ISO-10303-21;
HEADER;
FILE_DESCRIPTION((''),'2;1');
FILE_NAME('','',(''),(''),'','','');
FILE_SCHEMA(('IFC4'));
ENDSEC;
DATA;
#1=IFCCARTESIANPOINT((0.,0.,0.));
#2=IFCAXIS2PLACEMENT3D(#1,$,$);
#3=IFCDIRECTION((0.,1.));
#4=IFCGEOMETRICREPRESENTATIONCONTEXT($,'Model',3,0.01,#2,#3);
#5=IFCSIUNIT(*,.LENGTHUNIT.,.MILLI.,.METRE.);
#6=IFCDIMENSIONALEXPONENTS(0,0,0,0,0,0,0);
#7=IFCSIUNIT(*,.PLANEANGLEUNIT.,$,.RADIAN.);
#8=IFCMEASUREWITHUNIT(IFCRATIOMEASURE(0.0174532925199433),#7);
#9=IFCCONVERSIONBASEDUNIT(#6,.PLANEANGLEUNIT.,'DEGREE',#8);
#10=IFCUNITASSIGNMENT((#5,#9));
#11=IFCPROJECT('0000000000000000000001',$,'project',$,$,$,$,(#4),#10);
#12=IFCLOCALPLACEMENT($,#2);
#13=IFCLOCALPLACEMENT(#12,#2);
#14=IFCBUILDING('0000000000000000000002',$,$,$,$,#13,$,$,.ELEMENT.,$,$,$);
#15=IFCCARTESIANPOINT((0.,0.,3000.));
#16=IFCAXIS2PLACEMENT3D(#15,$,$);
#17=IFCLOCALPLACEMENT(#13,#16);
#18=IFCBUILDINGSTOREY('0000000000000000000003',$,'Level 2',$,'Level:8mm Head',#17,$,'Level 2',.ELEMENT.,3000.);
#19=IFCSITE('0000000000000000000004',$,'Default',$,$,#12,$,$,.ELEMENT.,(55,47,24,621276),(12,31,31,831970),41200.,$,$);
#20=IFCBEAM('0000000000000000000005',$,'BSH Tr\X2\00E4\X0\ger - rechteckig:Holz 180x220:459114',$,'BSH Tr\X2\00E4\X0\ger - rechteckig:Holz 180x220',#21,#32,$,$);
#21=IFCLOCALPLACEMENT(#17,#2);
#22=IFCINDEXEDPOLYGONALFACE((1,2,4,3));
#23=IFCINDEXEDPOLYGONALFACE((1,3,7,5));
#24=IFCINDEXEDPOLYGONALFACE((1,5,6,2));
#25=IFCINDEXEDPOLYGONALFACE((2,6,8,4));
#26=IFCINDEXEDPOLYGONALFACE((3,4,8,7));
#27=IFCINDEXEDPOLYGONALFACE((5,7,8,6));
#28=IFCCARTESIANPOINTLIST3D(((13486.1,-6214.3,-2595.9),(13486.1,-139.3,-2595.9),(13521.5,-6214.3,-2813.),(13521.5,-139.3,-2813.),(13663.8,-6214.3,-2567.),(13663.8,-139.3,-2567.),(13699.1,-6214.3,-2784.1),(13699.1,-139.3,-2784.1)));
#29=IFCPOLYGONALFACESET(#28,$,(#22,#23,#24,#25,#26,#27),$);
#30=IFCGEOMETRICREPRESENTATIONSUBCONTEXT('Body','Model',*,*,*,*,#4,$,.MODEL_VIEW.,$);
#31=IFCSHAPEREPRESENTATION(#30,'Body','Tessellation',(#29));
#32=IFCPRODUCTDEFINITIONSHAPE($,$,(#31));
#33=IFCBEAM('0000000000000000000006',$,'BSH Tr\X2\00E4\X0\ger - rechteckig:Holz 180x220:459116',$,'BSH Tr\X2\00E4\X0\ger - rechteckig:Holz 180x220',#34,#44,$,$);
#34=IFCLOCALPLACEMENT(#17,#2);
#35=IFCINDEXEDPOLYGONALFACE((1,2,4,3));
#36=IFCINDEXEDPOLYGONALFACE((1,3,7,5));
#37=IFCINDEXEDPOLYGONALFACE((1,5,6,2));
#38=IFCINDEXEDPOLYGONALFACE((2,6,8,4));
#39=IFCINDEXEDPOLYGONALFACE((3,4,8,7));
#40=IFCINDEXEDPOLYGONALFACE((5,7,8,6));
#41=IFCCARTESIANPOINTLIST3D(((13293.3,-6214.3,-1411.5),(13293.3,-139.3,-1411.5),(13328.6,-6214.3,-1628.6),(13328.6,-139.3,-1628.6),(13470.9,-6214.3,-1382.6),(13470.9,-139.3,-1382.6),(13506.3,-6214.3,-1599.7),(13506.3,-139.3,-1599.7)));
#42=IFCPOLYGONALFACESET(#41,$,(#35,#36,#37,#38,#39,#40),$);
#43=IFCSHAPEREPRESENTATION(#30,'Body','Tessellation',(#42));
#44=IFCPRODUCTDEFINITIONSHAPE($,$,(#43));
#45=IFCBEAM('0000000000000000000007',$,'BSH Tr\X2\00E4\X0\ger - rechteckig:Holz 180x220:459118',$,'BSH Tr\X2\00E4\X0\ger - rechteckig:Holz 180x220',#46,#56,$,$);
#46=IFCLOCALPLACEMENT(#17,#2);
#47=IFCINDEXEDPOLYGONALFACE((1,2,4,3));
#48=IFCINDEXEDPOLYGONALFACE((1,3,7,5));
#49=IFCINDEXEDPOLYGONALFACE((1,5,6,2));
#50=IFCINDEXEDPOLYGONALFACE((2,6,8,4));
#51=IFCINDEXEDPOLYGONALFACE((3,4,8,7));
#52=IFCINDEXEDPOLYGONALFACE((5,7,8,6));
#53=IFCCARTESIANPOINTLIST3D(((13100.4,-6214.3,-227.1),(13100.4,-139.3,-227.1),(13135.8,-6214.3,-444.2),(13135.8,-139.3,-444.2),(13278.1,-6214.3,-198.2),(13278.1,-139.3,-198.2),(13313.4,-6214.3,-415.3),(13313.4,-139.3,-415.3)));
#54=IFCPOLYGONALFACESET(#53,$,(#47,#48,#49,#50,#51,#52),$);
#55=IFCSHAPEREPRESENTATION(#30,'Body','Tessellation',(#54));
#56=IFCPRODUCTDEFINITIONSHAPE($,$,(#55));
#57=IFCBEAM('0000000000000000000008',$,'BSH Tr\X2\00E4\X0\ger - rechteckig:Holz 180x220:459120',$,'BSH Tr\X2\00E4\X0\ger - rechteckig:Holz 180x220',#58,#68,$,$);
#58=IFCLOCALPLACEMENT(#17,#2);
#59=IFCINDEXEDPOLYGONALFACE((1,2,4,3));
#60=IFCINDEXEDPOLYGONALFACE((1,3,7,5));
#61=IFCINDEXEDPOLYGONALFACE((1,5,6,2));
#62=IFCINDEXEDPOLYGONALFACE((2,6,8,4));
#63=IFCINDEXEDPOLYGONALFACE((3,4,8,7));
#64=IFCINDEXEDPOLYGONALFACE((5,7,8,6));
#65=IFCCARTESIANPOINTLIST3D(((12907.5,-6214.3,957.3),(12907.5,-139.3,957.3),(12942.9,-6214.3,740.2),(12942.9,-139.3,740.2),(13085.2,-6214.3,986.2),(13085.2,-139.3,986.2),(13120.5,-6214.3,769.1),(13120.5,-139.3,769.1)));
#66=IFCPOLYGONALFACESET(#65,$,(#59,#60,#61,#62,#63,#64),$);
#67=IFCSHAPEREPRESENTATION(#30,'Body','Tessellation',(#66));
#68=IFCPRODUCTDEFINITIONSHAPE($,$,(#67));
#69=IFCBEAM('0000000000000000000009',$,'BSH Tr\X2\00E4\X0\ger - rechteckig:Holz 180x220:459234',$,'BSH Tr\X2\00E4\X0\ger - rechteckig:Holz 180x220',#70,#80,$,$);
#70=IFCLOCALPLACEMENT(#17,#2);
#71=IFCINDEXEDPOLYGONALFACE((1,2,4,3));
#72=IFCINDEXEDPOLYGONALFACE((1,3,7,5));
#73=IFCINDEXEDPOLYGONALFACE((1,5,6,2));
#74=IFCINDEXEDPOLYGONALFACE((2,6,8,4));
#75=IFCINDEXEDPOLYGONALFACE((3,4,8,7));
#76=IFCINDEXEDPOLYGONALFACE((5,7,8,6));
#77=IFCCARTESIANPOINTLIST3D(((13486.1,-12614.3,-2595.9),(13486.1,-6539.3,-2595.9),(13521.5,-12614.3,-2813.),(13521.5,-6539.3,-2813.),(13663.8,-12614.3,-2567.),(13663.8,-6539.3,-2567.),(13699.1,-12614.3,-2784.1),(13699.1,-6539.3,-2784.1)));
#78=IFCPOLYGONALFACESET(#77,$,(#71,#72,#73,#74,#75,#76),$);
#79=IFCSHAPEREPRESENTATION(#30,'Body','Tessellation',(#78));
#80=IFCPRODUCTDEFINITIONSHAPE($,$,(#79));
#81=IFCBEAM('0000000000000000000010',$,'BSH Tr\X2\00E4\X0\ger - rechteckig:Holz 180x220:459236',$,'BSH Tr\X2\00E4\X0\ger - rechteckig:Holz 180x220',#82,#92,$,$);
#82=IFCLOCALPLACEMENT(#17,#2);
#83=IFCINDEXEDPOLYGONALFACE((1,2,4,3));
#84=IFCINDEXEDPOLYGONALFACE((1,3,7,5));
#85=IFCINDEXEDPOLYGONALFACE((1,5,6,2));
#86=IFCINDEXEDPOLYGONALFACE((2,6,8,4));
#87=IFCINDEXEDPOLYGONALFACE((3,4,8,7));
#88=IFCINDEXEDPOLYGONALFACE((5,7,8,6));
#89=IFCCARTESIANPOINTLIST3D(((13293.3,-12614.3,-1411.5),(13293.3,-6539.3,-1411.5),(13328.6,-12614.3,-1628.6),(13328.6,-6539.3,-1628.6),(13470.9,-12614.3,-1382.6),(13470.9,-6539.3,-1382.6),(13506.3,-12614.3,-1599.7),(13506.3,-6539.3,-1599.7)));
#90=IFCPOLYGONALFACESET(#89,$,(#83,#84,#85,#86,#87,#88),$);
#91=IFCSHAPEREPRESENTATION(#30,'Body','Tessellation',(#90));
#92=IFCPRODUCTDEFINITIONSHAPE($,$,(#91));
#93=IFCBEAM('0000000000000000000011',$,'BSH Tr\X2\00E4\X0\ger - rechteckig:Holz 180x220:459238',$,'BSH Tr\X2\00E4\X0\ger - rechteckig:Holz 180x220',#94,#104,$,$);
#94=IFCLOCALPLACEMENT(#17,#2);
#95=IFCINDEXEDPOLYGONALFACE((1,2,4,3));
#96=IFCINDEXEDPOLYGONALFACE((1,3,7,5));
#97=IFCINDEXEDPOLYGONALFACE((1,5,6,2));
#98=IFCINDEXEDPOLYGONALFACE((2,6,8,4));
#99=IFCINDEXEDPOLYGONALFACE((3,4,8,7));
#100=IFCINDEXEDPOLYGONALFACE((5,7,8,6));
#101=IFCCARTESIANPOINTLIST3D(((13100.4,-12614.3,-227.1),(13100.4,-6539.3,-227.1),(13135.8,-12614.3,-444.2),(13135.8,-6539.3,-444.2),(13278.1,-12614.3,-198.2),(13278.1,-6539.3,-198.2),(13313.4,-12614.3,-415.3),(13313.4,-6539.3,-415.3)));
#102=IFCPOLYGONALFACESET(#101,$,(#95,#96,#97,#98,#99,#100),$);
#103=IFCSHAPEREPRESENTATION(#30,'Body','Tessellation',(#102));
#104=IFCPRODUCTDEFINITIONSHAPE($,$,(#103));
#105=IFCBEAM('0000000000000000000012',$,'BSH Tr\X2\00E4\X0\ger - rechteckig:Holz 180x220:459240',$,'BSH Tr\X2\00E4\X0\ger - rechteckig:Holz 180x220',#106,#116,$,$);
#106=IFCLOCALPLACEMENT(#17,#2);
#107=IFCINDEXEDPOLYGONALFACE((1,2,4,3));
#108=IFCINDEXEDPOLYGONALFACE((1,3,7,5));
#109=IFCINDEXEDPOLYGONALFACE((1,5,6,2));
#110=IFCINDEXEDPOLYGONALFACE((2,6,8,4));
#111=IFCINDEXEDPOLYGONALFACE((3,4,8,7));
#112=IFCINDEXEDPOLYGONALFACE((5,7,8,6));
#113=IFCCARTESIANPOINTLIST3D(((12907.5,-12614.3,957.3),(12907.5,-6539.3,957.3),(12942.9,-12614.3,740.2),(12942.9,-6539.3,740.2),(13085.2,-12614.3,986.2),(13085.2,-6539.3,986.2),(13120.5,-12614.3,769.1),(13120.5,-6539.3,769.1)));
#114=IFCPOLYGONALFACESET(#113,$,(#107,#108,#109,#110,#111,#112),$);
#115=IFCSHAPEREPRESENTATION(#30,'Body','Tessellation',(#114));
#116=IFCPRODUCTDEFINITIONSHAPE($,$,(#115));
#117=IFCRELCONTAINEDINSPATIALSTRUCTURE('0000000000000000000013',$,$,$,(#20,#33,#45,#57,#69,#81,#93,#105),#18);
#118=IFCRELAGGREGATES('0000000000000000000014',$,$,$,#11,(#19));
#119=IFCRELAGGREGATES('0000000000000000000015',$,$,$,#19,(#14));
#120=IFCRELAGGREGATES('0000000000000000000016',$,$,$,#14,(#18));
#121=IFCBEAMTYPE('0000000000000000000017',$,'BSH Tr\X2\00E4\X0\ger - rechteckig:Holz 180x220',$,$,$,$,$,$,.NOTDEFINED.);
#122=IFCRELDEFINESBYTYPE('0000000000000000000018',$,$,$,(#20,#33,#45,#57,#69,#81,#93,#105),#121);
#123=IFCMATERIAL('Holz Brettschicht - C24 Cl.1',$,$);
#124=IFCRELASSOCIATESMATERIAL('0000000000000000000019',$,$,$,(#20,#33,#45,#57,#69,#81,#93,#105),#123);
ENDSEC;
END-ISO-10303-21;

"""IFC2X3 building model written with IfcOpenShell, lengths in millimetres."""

from ifc_helpers import new_model, entity, si_unit, converted_unit, direction, frame, frame_2d, origin, place, context, subcontext, project, spatial, rectangle, extrude, material, type_object, element, save


model = new_model("IFC2X3")

# Units and contexts
model_context = context("Model", 3, precision=0.01, world=origin(), true_north=direction((0.0, 1.0)))
body_context = subcontext(model_context, "Body", "Model", "MODEL_VIEW")
ifc_project = project(units=[si_unit("LENGTHUNIT", "METRE", prefix="MILLI"), converted_unit("PLANEANGLEUNIT", "DEGREE", entity("IfcRatioMeasure", 0.0174532925199433), si_unit("PLANEANGLEUNIT", "RADIAN"), dimensions=[0, 0, 0, 0, 0, 0, 0])], contexts=[model_context])

# Site, building, storey
site_placement = place(None, origin())
site = spatial("IfcSite", under=ifc_project, at=site_placement, Name="Default", CompositionType="ELEMENT", RefLatitude=(55, 47, 24, 621276), RefLongitude=(12, 31, 31, 831970), RefElevation=41200.0)
building_placement = place(site_placement, origin())
building = spatial("IfcBuilding", under=site, at=building_placement, CompositionType="ELEMENT")
storey_placement = place(building_placement, frame((0.0, 0.0, 3000.0)))
storey = spatial("IfcBuildingStorey", under=building, at=storey_placement, Name="Level 2", ObjectType="Level:8mm Head", LongName="Level 2", CompositionType="ELEMENT", Elevation=3000.0)

# Beams
ifc_material = material(Name="Holz Brettschicht - C24 Cl.1")
beam_type_1 = type_object("IfcBeamType", Name="BSH Träger - rechteckig:Holz 180x220", PredefinedType="NOTDEFINED")
beam_1_placement = place(storey_placement, frame((13681.5, -5476.8, -2675.5), z_axis=(0.0, 0.0, 1.0), x_axis=(0.0, 1.0, 0.0)))
element("IfcBeam", 1, at=beam_1_placement, inside=storey, type_object=beam_type_1, material=ifc_material, Name="BSH Träger - rechteckig:Holz 180x220:459114", ObjectType="BSH Träger - rechteckig:Holz 180x220", context=body_context, shape_type="SweptSolid", body=[
    extrude(rectangle(XDim=220.0, YDim=180.0, at=frame_2d((0.0, 0.0), x_axis=(1.0, 0.0))), frame((-737.5, 88.8, -14.5), z_axis=(1.0, 0.0, 0.0), x_axis=(0.0, 0.160724, 0.986999)), (0.0, 0.0, 1.0), 6075.0),
])
beam_2_placement = place(storey_placement, frame((13488.6, -5476.8, -1491.1), z_axis=(0.0, 0.0, 1.0), x_axis=(0.0, 1.0, 0.0)))
element("IfcBeam", 2, at=beam_2_placement, inside=storey, type_object=beam_type_1, material=ifc_material, Name="BSH Träger - rechteckig:Holz 180x220:459116", ObjectType="BSH Träger - rechteckig:Holz 180x220", context=body_context, shape_type="SweptSolid", body=[
    extrude(rectangle(XDim=220.0, YDim=180.0, at=frame_2d((0.0, 0.0), x_axis=(1.0, 0.0))), frame((-737.5, 88.8, -14.5), z_axis=(1.0, 0.0, 0.0), x_axis=(0.0, 0.160724, 0.986999)), (0.0, 0.0, 1.0), 6075.0),
])
beam_3_placement = place(storey_placement, frame((13295.7, -5476.8, -306.7), z_axis=(0.0, 0.0, 1.0), x_axis=(0.0, 1.0, 0.0)))
element("IfcBeam", 3, at=beam_3_placement, inside=storey, type_object=beam_type_1, material=ifc_material, Name="BSH Träger - rechteckig:Holz 180x220:459118", ObjectType="BSH Träger - rechteckig:Holz 180x220", context=body_context, shape_type="SweptSolid", body=[
    extrude(rectangle(XDim=220.0, YDim=180.0, at=frame_2d((0.0, 0.0), x_axis=(1.0, 0.0))), frame((-737.5, 88.8, -14.5), z_axis=(1.0, 0.0, 0.0), x_axis=(0.0, 0.160724, 0.986999)), (0.0, 0.0, 1.0), 6075.0),
])
beam_4_placement = place(storey_placement, frame((13102.9, -5476.8, 877.7), z_axis=(0.0, 0.0, 1.0), x_axis=(0.0, 1.0, 0.0)))
element("IfcBeam", 4, at=beam_4_placement, inside=storey, type_object=beam_type_1, material=ifc_material, Name="BSH Träger - rechteckig:Holz 180x220:459120", ObjectType="BSH Träger - rechteckig:Holz 180x220", context=body_context, shape_type="SweptSolid", body=[
    extrude(rectangle(XDim=220.0, YDim=180.0, at=frame_2d((0.0, 0.0), x_axis=(1.0, 0.0))), frame((-737.5, 88.8, -14.5), z_axis=(1.0, 0.0, 0.0), x_axis=(0.0, 0.160724, 0.986999)), (0.0, 0.0, 1.0), 6075.0),
])
beam_5_placement = place(storey_placement, frame((13681.5, -11876.8, -2675.5), z_axis=(0.0, 0.0, 1.0), x_axis=(0.0, 1.0, 0.0)))
element("IfcBeam", 5, at=beam_5_placement, inside=storey, type_object=beam_type_1, material=ifc_material, Name="BSH Träger - rechteckig:Holz 180x220:459234", ObjectType="BSH Träger - rechteckig:Holz 180x220", context=body_context, shape_type="SweptSolid", body=[
    extrude(rectangle(XDim=220.0, YDim=180.0, at=frame_2d((0.0, 0.0), x_axis=(1.0, 0.0))), frame((-737.5, 88.8, -14.5), z_axis=(1.0, 0.0, 0.0), x_axis=(0.0, 0.160724, 0.986999)), (0.0, 0.0, 1.0), 6075.0),
])
beam_6_placement = place(storey_placement, frame((13488.6, -11876.8, -1491.1), z_axis=(0.0, 0.0, 1.0), x_axis=(0.0, 1.0, 0.0)))
element("IfcBeam", 6, at=beam_6_placement, inside=storey, type_object=beam_type_1, material=ifc_material, Name="BSH Träger - rechteckig:Holz 180x220:459236", ObjectType="BSH Träger - rechteckig:Holz 180x220", context=body_context, shape_type="SweptSolid", body=[
    extrude(rectangle(XDim=220.0, YDim=180.0, at=frame_2d((0.0, 0.0), x_axis=(1.0, 0.0))), frame((-737.5, 88.8, -14.5), z_axis=(1.0, 0.0, 0.0), x_axis=(0.0, 0.160724, 0.986999)), (0.0, 0.0, 1.0), 6075.0),
])
beam_7_placement = place(storey_placement, frame((13295.7, -11876.8, -306.7), z_axis=(0.0, 0.0, 1.0), x_axis=(0.0, 1.0, 0.0)))
element("IfcBeam", 7, at=beam_7_placement, inside=storey, type_object=beam_type_1, material=ifc_material, Name="BSH Träger - rechteckig:Holz 180x220:459238", ObjectType="BSH Träger - rechteckig:Holz 180x220", context=body_context, shape_type="SweptSolid", body=[
    extrude(rectangle(XDim=220.0, YDim=180.0, at=frame_2d((0.0, 0.0), x_axis=(1.0, 0.0))), frame((-737.5, 88.8, -14.5), z_axis=(1.0, 0.0, 0.0), x_axis=(0.0, 0.160724, 0.986999)), (0.0, 0.0, 1.0), 6075.0),
])
beam_8_placement = place(storey_placement, frame((13102.9, -11876.8, 877.7), z_axis=(0.0, 0.0, 1.0), x_axis=(0.0, 1.0, 0.0)))
element("IfcBeam", 8, at=beam_8_placement, inside=storey, type_object=beam_type_1, material=ifc_material, Name="BSH Träger - rechteckig:Holz 180x220:459240", ObjectType="BSH Träger - rechteckig:Holz 180x220", context=body_context, shape_type="SweptSolid", body=[
    extrude(rectangle(XDim=220.0, YDim=180.0, at=frame_2d((0.0, 0.0), x_axis=(1.0, 0.0))), frame((-737.5, 88.8, -14.5), z_axis=(1.0, 0.0, 0.0), x_axis=(0.0, 0.160724, 0.986999)), (0.0, 0.0, 1.0), 6075.0),
])

save(model, "model.ifc")
